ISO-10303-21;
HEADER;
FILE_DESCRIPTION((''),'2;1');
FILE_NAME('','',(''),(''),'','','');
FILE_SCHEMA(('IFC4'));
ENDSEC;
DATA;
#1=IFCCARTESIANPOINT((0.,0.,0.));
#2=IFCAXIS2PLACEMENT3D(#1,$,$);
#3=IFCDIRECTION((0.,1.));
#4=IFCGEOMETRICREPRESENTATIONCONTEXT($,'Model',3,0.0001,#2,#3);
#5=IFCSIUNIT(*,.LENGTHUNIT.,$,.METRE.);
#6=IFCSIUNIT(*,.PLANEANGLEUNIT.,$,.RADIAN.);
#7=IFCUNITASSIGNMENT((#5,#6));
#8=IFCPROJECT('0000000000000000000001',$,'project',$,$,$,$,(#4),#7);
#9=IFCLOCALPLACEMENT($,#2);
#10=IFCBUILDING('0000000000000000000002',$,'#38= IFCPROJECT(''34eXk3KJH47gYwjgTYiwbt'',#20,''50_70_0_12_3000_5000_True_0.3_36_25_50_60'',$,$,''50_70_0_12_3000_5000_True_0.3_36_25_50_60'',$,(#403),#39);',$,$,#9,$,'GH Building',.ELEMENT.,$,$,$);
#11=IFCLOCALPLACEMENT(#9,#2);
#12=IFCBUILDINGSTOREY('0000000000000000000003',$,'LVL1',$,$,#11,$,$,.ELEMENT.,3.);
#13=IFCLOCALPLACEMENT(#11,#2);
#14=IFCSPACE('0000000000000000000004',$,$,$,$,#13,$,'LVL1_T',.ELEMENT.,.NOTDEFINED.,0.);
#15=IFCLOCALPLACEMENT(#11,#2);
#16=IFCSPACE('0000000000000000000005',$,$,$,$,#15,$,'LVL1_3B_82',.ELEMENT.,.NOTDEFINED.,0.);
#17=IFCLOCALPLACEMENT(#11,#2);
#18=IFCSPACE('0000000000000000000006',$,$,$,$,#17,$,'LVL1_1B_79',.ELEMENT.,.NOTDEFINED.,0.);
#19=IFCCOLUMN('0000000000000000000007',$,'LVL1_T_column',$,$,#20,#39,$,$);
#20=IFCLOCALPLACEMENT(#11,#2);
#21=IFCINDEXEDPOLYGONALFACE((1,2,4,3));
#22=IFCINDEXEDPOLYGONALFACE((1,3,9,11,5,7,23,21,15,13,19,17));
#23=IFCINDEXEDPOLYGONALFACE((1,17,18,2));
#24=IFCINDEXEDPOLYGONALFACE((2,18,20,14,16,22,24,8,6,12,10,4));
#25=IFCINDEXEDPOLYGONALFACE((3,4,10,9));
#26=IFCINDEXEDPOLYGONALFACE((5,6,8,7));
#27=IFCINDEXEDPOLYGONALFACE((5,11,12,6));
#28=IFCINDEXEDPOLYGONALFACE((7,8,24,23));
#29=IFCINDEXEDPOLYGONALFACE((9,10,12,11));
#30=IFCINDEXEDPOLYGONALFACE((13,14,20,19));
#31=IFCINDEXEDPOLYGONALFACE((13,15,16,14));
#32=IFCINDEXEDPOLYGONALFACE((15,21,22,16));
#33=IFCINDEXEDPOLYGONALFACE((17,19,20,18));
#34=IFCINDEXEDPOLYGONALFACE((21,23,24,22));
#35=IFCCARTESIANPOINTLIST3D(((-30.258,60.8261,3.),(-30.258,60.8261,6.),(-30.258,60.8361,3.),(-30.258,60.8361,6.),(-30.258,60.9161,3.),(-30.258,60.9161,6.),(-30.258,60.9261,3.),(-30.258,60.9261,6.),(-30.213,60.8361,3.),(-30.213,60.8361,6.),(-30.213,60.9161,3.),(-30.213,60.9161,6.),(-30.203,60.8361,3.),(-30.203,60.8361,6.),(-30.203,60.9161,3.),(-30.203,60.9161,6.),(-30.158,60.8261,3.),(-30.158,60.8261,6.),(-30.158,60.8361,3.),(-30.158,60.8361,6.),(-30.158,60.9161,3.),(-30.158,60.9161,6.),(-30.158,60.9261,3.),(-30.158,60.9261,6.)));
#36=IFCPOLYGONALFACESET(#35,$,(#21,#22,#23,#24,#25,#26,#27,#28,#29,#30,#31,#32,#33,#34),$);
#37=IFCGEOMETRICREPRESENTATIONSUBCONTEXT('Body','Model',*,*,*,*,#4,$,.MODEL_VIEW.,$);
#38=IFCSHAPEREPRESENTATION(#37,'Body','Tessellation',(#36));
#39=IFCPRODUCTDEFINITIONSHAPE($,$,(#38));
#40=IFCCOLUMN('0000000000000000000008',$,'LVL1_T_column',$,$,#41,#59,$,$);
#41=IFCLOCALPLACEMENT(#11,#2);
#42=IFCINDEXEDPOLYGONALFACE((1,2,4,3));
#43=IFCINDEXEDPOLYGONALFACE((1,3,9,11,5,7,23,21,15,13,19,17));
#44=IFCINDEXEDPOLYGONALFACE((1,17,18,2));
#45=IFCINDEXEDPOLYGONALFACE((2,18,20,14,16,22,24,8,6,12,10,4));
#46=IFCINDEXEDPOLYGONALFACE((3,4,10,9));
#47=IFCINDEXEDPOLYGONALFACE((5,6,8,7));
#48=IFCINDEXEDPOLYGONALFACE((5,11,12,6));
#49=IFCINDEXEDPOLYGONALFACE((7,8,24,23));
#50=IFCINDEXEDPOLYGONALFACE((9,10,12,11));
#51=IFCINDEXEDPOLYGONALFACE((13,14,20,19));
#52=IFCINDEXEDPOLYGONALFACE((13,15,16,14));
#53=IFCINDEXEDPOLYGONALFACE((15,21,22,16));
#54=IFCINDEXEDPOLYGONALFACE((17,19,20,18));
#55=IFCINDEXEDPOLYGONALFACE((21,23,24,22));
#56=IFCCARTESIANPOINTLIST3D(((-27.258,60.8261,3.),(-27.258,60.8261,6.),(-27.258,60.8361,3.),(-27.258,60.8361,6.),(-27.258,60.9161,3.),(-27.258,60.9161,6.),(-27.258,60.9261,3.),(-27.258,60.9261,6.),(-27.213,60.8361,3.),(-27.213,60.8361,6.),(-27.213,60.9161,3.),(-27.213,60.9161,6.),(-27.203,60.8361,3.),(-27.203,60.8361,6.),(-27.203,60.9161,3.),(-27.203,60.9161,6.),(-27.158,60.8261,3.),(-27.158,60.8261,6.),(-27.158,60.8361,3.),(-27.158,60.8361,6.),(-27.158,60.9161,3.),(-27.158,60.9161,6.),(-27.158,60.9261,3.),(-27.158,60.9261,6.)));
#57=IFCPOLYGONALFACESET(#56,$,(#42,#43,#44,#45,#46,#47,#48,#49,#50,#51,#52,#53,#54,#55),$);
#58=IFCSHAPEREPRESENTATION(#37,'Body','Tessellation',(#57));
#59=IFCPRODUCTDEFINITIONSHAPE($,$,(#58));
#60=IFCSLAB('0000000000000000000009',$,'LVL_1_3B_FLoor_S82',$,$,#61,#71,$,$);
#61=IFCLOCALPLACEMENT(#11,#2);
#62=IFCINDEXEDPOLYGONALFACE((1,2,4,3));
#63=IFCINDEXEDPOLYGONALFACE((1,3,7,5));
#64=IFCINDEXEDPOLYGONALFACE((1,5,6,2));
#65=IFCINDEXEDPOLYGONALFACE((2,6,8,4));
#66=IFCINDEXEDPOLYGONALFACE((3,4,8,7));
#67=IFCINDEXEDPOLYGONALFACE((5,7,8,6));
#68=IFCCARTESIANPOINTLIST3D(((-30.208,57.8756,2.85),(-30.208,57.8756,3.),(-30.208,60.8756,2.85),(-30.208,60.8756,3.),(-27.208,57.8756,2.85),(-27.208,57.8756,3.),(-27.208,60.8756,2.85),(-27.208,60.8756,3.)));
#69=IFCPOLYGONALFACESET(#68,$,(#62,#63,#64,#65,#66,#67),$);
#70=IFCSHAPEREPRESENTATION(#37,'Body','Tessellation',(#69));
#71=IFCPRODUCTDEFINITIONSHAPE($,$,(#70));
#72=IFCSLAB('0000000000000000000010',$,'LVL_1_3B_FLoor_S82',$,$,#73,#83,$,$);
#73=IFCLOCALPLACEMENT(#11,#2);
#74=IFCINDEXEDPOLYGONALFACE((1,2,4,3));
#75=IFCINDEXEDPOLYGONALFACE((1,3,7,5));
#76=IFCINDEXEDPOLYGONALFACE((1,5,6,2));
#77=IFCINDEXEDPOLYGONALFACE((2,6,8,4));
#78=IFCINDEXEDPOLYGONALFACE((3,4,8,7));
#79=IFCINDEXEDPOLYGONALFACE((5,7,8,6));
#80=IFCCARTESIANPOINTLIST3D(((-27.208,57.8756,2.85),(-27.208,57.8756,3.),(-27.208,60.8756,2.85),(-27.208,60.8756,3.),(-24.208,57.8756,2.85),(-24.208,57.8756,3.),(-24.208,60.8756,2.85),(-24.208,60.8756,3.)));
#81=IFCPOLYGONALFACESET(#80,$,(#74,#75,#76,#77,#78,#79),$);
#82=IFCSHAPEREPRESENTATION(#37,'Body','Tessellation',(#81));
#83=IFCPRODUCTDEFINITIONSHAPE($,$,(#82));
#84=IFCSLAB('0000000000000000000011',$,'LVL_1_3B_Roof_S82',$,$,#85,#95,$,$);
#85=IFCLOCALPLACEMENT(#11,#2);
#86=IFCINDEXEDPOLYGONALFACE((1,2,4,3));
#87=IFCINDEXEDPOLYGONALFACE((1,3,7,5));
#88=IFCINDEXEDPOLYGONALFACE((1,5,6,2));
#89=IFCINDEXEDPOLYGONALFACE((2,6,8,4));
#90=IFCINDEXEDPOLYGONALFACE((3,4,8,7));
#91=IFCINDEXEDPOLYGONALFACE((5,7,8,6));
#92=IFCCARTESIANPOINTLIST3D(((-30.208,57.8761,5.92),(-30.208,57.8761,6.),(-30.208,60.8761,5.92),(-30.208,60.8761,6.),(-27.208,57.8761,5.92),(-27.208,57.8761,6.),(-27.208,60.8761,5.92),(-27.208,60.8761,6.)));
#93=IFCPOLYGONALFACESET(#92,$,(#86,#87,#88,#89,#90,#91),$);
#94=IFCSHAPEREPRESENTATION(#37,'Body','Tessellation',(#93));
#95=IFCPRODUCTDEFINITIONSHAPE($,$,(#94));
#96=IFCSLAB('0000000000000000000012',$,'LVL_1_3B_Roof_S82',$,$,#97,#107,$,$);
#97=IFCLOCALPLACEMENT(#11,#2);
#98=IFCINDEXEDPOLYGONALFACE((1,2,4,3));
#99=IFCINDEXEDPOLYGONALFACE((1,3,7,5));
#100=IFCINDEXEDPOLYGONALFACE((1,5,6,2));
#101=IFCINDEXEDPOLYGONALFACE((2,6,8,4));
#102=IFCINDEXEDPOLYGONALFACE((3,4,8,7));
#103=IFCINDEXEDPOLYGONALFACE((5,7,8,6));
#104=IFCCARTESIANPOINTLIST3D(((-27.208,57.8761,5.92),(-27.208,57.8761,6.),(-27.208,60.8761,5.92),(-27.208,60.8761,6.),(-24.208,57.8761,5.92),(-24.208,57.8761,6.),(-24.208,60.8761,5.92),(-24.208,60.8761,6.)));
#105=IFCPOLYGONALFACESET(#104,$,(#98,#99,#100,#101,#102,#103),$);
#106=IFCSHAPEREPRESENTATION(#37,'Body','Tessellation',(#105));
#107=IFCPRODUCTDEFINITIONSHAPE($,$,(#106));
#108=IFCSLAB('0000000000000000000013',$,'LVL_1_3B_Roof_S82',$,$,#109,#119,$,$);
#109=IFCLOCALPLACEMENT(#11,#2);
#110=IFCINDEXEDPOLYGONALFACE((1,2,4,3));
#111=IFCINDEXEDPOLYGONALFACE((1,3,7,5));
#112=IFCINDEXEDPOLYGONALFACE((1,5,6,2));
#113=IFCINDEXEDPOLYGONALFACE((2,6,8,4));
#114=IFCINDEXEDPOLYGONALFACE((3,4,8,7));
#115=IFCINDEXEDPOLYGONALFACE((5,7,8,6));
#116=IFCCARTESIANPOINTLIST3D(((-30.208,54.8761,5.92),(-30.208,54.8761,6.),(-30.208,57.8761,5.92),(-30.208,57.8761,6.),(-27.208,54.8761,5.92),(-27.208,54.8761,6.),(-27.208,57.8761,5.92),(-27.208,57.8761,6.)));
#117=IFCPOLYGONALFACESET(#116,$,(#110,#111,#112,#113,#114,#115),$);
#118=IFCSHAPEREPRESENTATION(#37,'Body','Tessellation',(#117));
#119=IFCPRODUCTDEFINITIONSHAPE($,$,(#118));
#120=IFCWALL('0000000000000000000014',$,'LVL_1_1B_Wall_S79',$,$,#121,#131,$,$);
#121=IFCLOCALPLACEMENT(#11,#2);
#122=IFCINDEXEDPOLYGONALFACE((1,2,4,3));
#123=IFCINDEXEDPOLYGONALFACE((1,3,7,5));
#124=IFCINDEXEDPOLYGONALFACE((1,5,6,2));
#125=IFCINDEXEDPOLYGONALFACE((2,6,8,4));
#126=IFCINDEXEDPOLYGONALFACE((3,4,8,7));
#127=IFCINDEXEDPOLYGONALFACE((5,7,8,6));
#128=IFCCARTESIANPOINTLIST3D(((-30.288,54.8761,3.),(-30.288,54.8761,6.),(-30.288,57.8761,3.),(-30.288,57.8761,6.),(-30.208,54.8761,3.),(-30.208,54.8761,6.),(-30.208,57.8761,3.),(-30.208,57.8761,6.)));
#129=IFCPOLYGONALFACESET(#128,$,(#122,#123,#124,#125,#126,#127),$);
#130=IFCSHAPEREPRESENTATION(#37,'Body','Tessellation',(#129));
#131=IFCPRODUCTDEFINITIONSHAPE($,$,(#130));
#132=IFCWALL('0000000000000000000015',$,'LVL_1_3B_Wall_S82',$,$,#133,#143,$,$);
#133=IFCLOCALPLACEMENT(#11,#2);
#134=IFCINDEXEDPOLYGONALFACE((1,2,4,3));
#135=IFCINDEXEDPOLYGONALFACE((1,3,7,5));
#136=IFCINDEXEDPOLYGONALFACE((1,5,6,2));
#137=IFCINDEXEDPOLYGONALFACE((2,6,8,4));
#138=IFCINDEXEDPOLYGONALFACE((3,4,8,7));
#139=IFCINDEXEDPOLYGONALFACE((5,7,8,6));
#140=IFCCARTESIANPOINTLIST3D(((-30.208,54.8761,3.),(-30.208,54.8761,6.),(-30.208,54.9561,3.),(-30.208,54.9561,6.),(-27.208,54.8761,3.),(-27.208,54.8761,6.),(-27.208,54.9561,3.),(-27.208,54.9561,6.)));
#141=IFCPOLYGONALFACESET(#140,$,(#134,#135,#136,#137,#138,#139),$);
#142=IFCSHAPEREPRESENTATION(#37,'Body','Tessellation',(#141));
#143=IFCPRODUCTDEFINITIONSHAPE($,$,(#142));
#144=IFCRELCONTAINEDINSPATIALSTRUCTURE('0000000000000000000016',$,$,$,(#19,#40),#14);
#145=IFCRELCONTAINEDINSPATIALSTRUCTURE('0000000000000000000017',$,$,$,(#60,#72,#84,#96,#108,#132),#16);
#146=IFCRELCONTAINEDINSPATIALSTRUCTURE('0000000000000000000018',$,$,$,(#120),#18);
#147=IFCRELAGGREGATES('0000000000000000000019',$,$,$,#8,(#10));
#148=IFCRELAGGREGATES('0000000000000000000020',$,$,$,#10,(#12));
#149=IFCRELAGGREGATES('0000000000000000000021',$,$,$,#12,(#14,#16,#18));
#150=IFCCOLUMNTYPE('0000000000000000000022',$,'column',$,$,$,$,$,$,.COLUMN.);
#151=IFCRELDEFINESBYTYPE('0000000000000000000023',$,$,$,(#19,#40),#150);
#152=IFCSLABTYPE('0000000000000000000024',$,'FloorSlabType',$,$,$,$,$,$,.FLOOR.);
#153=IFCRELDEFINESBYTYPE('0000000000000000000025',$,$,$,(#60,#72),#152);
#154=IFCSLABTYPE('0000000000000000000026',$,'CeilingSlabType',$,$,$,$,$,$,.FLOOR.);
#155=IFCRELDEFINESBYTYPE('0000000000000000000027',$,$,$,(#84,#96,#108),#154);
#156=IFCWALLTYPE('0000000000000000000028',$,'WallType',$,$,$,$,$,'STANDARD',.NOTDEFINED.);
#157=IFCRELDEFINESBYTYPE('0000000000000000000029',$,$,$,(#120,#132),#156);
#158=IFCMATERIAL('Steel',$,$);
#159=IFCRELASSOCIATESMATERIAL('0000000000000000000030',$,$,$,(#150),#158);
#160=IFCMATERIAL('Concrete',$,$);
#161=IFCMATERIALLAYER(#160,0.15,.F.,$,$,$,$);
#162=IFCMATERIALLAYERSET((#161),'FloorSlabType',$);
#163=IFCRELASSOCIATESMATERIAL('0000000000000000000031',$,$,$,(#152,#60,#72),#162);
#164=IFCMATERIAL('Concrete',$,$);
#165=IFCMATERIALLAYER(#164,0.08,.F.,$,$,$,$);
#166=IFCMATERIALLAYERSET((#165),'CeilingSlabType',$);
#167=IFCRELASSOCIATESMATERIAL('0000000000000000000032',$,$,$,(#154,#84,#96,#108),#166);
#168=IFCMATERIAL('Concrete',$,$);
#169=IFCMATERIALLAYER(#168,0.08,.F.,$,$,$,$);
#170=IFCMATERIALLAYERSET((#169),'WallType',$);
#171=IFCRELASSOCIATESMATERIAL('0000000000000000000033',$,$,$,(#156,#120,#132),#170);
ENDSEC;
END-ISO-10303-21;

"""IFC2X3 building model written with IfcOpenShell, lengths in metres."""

from ifc_helpers import new_model, si_unit, direction, frame, frame_2d, origin, origin_2d, place, context, subcontext, project, spatial, rectangle, i_section, extrude, material, layer, layer_set, layer_usage, type_object, element, save


model = new_model("IFC2X3")

# Units and contexts
model_context = context("Model", 3, precision=0.0001, world=origin(), true_north=direction((0.0, 1.0)))
body_context = subcontext(model_context, "Body", "Model", "MODEL_VIEW")
ifc_project = project(units=[si_unit("LENGTHUNIT", "METRE"), si_unit("PLANEANGLEUNIT", "RADIAN")], contexts=[model_context])

# Building, storey, space
building_placement = place(None, origin())
building = spatial("IfcBuilding", under=ifc_project, at=building_placement, Name="#38= IFCPROJECT('34eXk3KJH47gYwjgTYiwbt',#20,'50_70_0_12_3000_5000_True_0.3_36_25_50_60',$,$,'50_70_0_12_3000_5000_True_0.3_36_25_50_60',$,(#403),#39);", LongName="GH Building", CompositionType="ELEMENT")
storey_placement = place(building_placement, origin())
storey = spatial("IfcBuildingStorey", under=building, at=storey_placement, Name="LVL1", CompositionType="ELEMENT", Elevation=3.0)
space_1_placement = place(storey_placement, origin())
space_1 = spatial("IfcSpace", under=storey, at=space_1_placement, LongName="LVL1_T", CompositionType="ELEMENT", InteriorOrExteriorSpace="NOTDEFINED", ElevationWithFlooring=0.0)

# Columns
ifc_material_1 = material(Name="Steel")
column_type = type_object("IfcColumnType", Name="column", PredefinedType="COLUMN", material=ifc_material_1)
for number, where, name in (
    (1, (-30.208, 60.8761, 3.0), "LVL1_T_column"),
    (2, (-27.208, 60.8761, 3.0), "LVL1_T_column"),
):
    element("IfcColumn", number, at=place(space_1_placement, frame(where)), inside=space_1, type_object=column_type, Name=name, context=body_context, shape_type="SweptSolid", body=[
        extrude(i_section(OverallWidth=0.1, OverallDepth=0.1, WebThickness=0.01, FlangeThickness=0.01, at=origin_2d()), origin(), (0.0, 0.0, 1.0), 3.0),
    ])

# Shared definitions
space_2_placement = place(storey_placement, origin())
space_2 = spatial("IfcSpace", under=storey, at=space_2_placement, LongName="LVL1_3B_82", CompositionType="ELEMENT", InteriorOrExteriorSpace="NOTDEFINED", ElevationWithFlooring=0.0)

# Slabs
ifc_material_2 = material(Name="Concrete")
ifc_layer_1 = layer(ifc_material_2, 0.15, ventilated=False)
ifc_layer_set_1 = layer_set([ifc_layer_1], Name="FloorSlabType")
ifc_layer_usage_1 = layer_usage(ifc_layer_set_1, "AXIS3", "NEGATIVE", -0.15)
slab_type_1 = type_object("IfcSlabType", Name="FloorSlabType", PredefinedType="FLOOR", material=ifc_layer_set_1)
slab_1_placement = place(space_2_placement, frame((-30.208, 57.8756, 2.85)))
element("IfcSlab", 3, at=slab_1_placement, inside=space_2, type_object=slab_type_1, material=ifc_layer_usage_1, Name="LVL_1_3B_FLoor_S82", context=body_context, shape_type="SweptSolid", body=[
    extrude(rectangle(XDim=3.0, YDim=3.0, at=frame_2d((1.5, 1.5))), origin(), (0.0, 0.0, 1.0), 0.15),
])
ifc_layer_usage_2 = layer_usage(ifc_layer_set_1, "AXIS3", "NEGATIVE", -0.15)
slab_2_placement = place(space_2_placement, frame((-27.208, 57.8756, 2.85)))
element("IfcSlab", 4, at=slab_2_placement, inside=space_2, type_object=slab_type_1, material=ifc_layer_usage_2, Name="LVL_1_3B_FLoor_S82", context=body_context, shape_type="SweptSolid", body=[
    extrude(rectangle(XDim=3.0, YDim=3.0, at=frame_2d((1.5, 1.5))), origin(), (0.0, 0.0, 1.0), 0.15),
])
ifc_material_3 = material(Name="Concrete")
ifc_layer_2 = layer(ifc_material_3, 0.08, ventilated=False)
ifc_layer_set_2 = layer_set([ifc_layer_2], Name="CeilingSlabType")
ifc_layer_usage_3 = layer_usage(ifc_layer_set_2, "AXIS3", "NEGATIVE", -0.08)
slab_type_2 = type_object("IfcSlabType", Name="CeilingSlabType", PredefinedType="FLOOR", material=ifc_layer_set_2)
slab_3_placement = place(space_2_placement, frame((-30.208, 57.8761, 5.92)))
element("IfcSlab", 5, at=slab_3_placement, inside=space_2, type_object=slab_type_2, material=ifc_layer_usage_3, Name="LVL_1_3B_Roof_S82", context=body_context, shape_type="SweptSolid", body=[
    extrude(rectangle(XDim=3.0, YDim=3.0, at=frame_2d((1.5, 1.5))), origin(), (0.0, 0.0, 1.0), 0.08),
])
ifc_layer_usage_4 = layer_usage(ifc_layer_set_2, "AXIS3", "NEGATIVE", -0.08)
slab_4_placement = place(space_2_placement, frame((-27.208, 57.8761, 5.92)))
element("IfcSlab", 6, at=slab_4_placement, inside=space_2, type_object=slab_type_2, material=ifc_layer_usage_4, Name="LVL_1_3B_Roof_S82", context=body_context, shape_type="SweptSolid", body=[
    extrude(rectangle(XDim=3.0, YDim=3.0, at=frame_2d((1.5, 1.5))), origin(), (0.0, 0.0, 1.0), 0.08),
])
ifc_layer_usage_5 = layer_usage(ifc_layer_set_2, "AXIS3", "NEGATIVE", -0.08)
slab_5_placement = place(space_2_placement, frame((-30.208, 54.8761, 5.92)))
element("IfcSlab", 7, at=slab_5_placement, inside=space_2, type_object=slab_type_2, material=ifc_layer_usage_5, Name="LVL_1_3B_Roof_S82", context=body_context, shape_type="SweptSolid", body=[
    extrude(rectangle(XDim=3.0, YDim=3.0, at=frame_2d((1.5, 1.5))), origin(), (0.0, 0.0, 1.0), 0.08),
])

# Shared definitions
ifc_material_4 = material(Name="Concrete")
ifc_layer_3 = layer(ifc_material_4, 0.08, ventilated=False)
ifc_layer_set_3 = layer_set([ifc_layer_3], Name="WallType")
wall_type = type_object("IfcWallType", Name="WallType", ElementType="STANDARD", PredefinedType="NOTDEFINED", material=ifc_layer_set_3)

# Shared definitions
space_3_placement = place(storey_placement, origin())
space_3 = spatial("IfcSpace", under=storey, at=space_3_placement, LongName="LVL1_1B_79", CompositionType="ELEMENT", InteriorOrExteriorSpace="NOTDEFINED", ElevationWithFlooring=0.0)

# Wall
ifc_layer_usage_6 = layer_usage(ifc_layer_set_3, "AXIS2", "NEGATIVE", 0.0)
wall_1_placement = place(space_3_placement, frame((-30.208, 57.8761, 3.0), z_axis=(0.0, 0.0, 1.0), x_axis=(0.0, -1.0, 0.0)))
element("IfcWall", 8, at=wall_1_placement, inside=space_3, type_object=wall_type, material=ifc_layer_usage_6, Name="LVL_1_1B_Wall_S79", context=body_context, shape_type="SweptSolid", body=[
    extrude(rectangle(XDim=3.0, YDim=0.08, at=frame_2d((1.5, -0.04))), origin(), (0.0, 0.0, 1.0), 3.0),
])

# Wall
ifc_layer_usage_7 = layer_usage(ifc_layer_set_3, "AXIS2", "NEGATIVE", 0.0)
wall_2_placement = place(space_2_placement, frame((-27.208, 54.8761, 3.0), z_axis=(0.0, 0.0, 1.0), x_axis=(-1.0, 0.0, 0.0)))
element("IfcWall", 9, at=wall_2_placement, inside=space_2, type_object=wall_type, material=ifc_layer_usage_7, Name="LVL_1_3B_Wall_S82", context=body_context, shape_type="SweptSolid", body=[
    extrude(rectangle(XDim=3.0, YDim=0.08, at=frame_2d((1.5, -0.04))), origin(), (0.0, 0.0, 1.0), 3.0),
])

save(model, "model.ifc")
